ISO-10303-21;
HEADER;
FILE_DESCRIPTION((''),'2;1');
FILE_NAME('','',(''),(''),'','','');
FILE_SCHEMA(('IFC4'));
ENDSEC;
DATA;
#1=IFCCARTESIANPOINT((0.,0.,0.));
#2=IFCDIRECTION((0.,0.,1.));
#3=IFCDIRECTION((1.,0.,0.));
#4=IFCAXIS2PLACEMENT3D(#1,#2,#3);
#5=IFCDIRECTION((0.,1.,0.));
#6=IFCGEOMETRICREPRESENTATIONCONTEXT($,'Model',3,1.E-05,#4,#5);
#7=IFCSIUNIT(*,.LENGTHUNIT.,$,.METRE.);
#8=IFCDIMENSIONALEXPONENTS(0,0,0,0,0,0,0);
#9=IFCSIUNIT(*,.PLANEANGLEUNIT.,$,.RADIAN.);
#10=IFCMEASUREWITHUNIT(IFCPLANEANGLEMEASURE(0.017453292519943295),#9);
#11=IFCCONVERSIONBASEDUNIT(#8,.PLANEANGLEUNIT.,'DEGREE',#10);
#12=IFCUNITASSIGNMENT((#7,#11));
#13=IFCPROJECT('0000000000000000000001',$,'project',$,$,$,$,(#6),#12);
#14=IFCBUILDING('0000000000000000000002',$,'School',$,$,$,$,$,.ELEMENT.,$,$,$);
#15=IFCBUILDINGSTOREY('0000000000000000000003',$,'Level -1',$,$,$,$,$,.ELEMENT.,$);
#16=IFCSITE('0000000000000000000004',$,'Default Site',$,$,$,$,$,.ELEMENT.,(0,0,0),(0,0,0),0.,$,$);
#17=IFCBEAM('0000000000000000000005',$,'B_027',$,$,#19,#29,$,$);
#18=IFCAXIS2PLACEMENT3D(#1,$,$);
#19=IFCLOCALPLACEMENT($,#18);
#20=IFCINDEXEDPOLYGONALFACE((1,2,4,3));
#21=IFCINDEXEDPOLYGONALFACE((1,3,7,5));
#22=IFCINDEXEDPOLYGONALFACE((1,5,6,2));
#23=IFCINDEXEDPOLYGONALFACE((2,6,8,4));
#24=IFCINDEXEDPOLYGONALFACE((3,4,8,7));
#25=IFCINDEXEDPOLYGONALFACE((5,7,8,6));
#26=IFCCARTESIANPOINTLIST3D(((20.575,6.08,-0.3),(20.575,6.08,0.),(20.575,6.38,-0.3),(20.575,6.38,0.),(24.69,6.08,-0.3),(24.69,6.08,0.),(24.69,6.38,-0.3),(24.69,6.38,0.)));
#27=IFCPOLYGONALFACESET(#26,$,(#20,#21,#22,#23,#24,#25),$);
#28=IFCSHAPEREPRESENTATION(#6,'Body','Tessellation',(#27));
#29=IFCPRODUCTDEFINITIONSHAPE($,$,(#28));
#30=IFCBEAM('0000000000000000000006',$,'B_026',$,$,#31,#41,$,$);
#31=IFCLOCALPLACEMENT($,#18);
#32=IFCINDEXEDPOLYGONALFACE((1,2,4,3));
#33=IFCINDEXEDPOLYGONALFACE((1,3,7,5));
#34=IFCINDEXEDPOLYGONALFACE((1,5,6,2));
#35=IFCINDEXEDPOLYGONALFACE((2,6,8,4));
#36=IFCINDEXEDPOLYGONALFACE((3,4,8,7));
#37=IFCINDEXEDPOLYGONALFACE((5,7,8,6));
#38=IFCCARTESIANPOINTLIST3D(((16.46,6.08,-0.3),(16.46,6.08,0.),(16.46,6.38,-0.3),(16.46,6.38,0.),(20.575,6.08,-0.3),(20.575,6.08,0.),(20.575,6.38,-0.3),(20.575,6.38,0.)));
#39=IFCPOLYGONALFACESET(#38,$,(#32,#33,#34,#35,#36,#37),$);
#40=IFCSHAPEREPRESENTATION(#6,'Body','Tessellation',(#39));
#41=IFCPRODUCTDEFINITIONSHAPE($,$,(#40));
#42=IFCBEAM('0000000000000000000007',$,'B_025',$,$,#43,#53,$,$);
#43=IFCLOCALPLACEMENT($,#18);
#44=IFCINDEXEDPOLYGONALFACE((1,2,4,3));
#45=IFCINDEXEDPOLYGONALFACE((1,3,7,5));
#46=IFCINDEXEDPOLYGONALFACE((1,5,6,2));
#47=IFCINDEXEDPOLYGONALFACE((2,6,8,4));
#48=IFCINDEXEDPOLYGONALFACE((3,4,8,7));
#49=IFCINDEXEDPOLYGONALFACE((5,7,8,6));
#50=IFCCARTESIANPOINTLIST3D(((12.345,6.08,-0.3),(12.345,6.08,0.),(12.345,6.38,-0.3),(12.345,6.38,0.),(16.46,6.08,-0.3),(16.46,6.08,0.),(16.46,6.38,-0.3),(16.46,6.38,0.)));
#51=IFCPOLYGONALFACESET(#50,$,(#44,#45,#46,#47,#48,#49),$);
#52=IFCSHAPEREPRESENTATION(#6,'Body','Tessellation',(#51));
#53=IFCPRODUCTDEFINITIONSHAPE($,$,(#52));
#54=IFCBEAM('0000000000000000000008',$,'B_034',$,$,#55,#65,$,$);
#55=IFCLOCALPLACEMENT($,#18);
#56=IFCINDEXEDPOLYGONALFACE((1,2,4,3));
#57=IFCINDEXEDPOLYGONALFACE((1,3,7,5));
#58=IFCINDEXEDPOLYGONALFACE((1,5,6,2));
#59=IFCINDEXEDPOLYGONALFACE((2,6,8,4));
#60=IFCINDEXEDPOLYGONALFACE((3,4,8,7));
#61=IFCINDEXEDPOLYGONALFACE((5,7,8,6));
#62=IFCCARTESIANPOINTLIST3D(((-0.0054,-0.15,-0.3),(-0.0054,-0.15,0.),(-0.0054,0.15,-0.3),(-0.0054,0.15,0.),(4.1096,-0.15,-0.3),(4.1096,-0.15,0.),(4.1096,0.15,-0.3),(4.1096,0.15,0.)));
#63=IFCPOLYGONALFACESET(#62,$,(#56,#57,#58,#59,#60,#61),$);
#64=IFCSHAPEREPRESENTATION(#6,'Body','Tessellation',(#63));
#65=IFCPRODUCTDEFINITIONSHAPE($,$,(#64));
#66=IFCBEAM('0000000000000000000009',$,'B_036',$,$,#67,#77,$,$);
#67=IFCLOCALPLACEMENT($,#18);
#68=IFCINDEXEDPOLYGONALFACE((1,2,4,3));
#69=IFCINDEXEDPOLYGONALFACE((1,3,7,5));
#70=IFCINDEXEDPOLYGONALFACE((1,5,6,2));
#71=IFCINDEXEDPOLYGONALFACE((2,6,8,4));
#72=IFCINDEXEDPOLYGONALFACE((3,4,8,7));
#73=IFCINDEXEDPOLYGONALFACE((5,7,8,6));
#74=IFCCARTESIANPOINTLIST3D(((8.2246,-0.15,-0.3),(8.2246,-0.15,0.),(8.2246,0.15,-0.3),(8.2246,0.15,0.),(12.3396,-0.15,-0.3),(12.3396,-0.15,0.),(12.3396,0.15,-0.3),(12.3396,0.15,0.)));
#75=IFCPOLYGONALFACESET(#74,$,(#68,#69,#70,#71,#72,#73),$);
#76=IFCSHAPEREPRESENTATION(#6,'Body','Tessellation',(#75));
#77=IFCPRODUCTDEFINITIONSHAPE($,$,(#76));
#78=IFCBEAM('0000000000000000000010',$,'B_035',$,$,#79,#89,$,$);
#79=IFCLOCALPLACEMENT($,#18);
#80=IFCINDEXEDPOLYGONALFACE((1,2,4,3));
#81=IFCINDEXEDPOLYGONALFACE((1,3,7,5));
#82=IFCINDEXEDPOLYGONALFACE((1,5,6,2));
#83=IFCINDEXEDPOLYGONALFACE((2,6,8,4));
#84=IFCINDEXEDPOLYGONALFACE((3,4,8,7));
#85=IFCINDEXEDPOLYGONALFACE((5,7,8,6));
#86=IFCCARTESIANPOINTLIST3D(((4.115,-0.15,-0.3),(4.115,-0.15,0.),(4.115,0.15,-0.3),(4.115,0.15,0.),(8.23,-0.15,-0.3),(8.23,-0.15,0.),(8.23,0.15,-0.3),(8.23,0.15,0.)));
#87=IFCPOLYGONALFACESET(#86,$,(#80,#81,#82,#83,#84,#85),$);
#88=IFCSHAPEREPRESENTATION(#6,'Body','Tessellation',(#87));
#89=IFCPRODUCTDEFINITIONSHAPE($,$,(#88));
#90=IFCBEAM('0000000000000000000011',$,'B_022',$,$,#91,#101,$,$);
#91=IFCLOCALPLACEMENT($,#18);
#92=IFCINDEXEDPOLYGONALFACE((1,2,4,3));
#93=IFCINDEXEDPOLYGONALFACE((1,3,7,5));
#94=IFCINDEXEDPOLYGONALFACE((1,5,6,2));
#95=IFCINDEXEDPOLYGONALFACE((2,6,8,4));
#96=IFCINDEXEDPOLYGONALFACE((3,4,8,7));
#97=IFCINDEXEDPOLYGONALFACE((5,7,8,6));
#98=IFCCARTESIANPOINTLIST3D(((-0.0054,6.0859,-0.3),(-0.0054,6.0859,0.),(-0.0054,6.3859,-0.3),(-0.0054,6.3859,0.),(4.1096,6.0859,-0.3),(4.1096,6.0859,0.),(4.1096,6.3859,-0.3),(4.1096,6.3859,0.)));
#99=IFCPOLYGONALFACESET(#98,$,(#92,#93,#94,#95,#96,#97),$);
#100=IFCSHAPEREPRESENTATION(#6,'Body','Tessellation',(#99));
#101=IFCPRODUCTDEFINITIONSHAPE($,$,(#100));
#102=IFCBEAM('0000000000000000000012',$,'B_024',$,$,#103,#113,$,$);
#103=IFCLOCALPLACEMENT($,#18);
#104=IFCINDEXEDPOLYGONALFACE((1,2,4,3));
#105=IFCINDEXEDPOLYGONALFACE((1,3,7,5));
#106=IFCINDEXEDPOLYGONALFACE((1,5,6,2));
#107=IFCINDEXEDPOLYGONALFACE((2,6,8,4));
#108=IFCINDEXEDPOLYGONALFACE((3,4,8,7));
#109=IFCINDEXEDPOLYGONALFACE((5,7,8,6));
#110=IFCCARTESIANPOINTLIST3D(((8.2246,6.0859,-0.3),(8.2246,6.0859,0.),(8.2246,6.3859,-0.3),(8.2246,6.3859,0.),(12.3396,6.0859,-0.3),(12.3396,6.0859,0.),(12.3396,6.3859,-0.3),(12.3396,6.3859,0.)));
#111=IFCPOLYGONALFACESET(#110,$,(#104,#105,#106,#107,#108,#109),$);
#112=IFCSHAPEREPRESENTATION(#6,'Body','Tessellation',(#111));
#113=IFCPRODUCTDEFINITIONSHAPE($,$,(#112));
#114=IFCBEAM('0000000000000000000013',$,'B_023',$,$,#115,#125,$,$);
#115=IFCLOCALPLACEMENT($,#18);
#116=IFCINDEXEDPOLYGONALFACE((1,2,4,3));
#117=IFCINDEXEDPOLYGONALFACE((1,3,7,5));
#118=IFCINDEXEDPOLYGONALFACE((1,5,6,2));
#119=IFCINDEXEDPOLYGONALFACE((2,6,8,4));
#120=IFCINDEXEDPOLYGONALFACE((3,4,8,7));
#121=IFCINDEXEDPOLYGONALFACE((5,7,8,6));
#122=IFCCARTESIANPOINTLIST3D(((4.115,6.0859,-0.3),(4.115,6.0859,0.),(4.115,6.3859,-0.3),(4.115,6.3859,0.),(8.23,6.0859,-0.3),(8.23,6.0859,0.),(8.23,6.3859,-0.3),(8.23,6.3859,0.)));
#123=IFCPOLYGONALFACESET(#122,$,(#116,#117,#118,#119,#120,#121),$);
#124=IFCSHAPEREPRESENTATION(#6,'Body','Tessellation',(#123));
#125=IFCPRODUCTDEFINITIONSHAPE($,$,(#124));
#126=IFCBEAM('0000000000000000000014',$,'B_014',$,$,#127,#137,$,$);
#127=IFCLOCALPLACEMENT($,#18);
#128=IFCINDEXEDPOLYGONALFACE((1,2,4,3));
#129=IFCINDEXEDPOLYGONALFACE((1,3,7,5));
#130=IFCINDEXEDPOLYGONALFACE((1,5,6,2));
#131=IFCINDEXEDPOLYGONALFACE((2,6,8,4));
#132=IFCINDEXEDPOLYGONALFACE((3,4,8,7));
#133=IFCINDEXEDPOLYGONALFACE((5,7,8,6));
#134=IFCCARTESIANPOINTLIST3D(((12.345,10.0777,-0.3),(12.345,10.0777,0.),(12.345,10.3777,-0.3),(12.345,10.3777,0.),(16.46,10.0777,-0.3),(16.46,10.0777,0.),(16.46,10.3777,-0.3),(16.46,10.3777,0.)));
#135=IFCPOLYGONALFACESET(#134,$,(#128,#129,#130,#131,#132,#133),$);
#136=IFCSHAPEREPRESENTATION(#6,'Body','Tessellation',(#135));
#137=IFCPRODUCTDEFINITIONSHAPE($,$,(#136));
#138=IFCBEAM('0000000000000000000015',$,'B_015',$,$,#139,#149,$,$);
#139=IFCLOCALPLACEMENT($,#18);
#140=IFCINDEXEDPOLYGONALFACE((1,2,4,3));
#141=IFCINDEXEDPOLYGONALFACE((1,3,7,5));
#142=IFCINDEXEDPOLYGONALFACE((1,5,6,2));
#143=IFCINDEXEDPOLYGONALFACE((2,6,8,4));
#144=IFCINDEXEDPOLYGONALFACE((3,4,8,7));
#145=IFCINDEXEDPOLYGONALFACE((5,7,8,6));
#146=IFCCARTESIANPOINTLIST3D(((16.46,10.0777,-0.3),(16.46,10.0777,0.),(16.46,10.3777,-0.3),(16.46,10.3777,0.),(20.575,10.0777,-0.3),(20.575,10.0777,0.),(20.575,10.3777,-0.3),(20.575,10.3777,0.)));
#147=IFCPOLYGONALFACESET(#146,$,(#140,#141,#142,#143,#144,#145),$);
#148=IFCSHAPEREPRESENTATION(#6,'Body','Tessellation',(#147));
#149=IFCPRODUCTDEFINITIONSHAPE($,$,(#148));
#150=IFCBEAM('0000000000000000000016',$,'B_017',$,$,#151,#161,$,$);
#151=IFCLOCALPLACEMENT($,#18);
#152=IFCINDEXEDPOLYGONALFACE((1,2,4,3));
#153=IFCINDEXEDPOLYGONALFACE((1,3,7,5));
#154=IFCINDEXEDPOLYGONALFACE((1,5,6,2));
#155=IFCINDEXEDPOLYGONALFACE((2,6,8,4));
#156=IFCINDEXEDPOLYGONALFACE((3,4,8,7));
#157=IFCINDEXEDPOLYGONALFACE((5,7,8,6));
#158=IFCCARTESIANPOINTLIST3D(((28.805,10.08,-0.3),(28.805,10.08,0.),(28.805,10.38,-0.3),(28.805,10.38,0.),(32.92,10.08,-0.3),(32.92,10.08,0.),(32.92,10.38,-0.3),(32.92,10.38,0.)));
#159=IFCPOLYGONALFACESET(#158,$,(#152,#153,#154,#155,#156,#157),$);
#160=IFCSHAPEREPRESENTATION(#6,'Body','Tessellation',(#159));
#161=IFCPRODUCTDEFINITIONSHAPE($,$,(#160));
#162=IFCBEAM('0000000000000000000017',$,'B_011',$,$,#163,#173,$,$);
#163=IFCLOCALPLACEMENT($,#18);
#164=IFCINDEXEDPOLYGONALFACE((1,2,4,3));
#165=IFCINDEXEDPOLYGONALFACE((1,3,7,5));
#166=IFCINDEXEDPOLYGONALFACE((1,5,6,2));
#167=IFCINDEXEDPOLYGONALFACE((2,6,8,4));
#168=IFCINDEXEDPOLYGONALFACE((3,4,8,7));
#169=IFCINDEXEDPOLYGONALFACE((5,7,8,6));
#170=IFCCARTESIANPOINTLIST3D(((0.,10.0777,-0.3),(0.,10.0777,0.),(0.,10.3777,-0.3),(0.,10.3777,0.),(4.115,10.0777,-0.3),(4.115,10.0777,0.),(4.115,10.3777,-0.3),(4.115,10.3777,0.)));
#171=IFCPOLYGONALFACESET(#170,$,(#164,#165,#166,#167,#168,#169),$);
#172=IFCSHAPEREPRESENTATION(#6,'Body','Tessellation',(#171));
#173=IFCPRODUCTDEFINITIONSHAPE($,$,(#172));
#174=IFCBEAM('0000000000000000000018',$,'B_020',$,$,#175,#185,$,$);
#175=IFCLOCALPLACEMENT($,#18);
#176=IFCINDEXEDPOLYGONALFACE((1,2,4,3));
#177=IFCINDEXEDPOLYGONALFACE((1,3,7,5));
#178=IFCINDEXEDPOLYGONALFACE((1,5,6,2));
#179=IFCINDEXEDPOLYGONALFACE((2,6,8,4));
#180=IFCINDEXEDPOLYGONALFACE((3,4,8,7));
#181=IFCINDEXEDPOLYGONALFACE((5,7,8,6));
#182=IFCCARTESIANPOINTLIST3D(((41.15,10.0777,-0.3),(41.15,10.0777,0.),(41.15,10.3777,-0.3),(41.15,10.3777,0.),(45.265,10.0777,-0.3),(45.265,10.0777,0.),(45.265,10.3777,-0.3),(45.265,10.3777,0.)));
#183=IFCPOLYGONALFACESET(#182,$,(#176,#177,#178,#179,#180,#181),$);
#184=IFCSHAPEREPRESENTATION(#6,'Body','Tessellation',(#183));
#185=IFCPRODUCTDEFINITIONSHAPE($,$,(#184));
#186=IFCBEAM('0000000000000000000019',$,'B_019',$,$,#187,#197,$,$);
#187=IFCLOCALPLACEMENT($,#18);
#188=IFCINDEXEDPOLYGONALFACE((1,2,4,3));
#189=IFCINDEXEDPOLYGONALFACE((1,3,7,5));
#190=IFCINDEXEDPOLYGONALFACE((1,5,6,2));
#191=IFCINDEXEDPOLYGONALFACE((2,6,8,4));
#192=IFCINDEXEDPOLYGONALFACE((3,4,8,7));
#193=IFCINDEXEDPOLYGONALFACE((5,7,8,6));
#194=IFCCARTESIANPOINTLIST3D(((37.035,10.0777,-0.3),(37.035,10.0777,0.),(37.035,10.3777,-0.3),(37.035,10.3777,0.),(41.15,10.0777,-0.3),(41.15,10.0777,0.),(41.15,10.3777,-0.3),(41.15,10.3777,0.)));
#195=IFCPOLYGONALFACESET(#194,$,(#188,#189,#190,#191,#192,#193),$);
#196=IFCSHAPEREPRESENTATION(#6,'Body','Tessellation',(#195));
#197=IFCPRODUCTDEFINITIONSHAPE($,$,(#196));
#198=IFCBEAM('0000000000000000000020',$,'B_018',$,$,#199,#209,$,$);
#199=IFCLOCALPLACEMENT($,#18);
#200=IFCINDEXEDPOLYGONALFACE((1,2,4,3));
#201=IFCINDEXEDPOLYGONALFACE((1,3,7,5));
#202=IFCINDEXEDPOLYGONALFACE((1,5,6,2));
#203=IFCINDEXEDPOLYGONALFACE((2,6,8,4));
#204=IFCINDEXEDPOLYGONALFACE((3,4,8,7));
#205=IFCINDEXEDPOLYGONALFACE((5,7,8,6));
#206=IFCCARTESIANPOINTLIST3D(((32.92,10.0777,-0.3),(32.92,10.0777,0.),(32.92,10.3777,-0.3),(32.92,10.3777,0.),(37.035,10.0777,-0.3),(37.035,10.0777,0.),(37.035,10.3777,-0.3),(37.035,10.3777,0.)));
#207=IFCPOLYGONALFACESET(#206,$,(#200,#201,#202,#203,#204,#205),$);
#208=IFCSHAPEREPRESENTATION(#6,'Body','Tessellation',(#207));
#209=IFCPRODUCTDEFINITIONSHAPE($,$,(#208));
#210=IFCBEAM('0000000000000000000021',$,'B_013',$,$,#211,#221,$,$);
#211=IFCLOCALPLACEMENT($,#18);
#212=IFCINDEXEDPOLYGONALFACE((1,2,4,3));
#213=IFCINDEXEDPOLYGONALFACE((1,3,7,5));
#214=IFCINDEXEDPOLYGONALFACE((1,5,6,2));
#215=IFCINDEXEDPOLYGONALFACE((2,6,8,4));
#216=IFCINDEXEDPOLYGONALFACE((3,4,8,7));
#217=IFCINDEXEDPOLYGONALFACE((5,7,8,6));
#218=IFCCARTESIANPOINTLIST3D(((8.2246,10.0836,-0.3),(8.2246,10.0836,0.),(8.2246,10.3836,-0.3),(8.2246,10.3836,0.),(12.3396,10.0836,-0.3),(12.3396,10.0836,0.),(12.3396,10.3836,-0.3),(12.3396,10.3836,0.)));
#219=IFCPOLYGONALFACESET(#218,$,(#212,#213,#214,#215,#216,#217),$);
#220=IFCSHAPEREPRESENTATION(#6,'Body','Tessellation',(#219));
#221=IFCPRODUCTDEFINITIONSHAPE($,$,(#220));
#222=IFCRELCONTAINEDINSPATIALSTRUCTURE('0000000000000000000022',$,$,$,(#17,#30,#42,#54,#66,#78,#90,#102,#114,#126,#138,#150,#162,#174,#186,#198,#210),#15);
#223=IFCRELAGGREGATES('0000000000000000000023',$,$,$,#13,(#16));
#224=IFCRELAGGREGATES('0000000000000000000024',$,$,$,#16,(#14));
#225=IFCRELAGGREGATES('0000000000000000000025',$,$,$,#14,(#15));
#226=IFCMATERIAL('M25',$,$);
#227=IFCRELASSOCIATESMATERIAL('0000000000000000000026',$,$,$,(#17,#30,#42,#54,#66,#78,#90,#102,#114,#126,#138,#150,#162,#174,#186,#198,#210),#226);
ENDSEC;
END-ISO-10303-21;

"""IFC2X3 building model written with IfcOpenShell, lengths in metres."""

from ifc_helpers import new_model, entity, si_unit, converted_unit, direction, frame, frame_2d, origin_with_axes, place, context, project, spatial, rectangle, extrude, material, element, save


model = new_model("IFC2X3")

# Units and contexts
model_context = context("Model", 3, precision=1e-05, world=origin_with_axes(), true_north=direction((0.0, 1.0, 0.0)))
ifc_project = project(units=[si_unit("LENGTHUNIT", "METRE"), converted_unit("PLANEANGLEUNIT", "DEGREE", entity("IfcPlaneAngleMeasure", 0.017453292519943295), si_unit("PLANEANGLEUNIT", "RADIAN"), dimensions=[0, 0, 0, 0, 0, 0, 0])], contexts=[model_context])

# Site, building, storey
site = spatial("IfcSite", under=ifc_project, Name="Default Site", CompositionType="ELEMENT", RefLatitude=(0, 0, 0), RefLongitude=(0, 0, 0), RefElevation=0.0)
building = spatial("IfcBuilding", under=site, Name="School", CompositionType="ELEMENT")
storey = spatial("IfcBuildingStorey", under=building, Name="Level -1", CompositionType="ELEMENT")

# Beams
ifc_material = material(Name="M25")
placement = place(None, origin_with_axes())
element("IfcBeam", 1, at=placement, inside=storey, material=ifc_material, Name="B_027", context=model_context, shape_type="SweptSolid", body=[
    extrude(rectangle(XDim=0.3, YDim=0.3, at=frame_2d((0.0, 0.0), x_axis=(0.0, 1.0, 0.0))), frame((20.575, 6.23, -0.15), z_axis=(1.0, 0.0, 0.0), x_axis=(0.0, 0.0, -1.0)), (0.0, 0.0, 1.0), 4.115),
])
element("IfcBeam", 2, at=placement, inside=storey, material=ifc_material, Name="B_026", context=model_context, shape_type="SweptSolid", body=[
    extrude(rectangle(XDim=0.3, YDim=0.3, at=frame_2d((0.0, 0.0), x_axis=(0.0, 1.0, 0.0))), frame((16.46, 6.23, -0.15), z_axis=(1.0, 0.0, 0.0), x_axis=(0.0, 0.0, -1.0)), (0.0, 0.0, 1.0), 4.115),
])
element("IfcBeam", 3, at=placement, inside=storey, material=ifc_material, Name="B_025", context=model_context, shape_type="SweptSolid", body=[
    extrude(rectangle(XDim=0.3, YDim=0.3, at=frame_2d((0.0, 0.0), x_axis=(0.0, 1.0, 0.0))), frame((12.345, 6.23, -0.15), z_axis=(1.0, 0.0, 0.0), x_axis=(0.0, 0.0, -1.0)), (0.0, 0.0, 1.0), 4.115),
])
element("IfcBeam", 4, at=placement, inside=storey, material=ifc_material, Name="B_034", context=model_context, shape_type="SweptSolid", body=[
    extrude(rectangle(XDim=0.3, YDim=0.3, at=frame_2d((0.0, 0.0), x_axis=(0.0, 1.0, 0.0))), frame((-0.0054, 0.0, -0.15), z_axis=(1.0, 0.0, 0.0), x_axis=(0.0, 0.0, -1.0)), (0.0, 0.0, 1.0), 4.115),
])
element("IfcBeam", 5, at=placement, inside=storey, material=ifc_material, Name="B_036", context=model_context, shape_type="SweptSolid", body=[
    extrude(rectangle(XDim=0.3, YDim=0.3, at=frame_2d((0.0, 0.0), x_axis=(0.0, 1.0, 0.0))), frame((8.2246, 0.0, -0.15), z_axis=(1.0, 0.0, 0.0), x_axis=(0.0, 0.0, -1.0)), (0.0, 0.0, 1.0), 4.115),
])
element("IfcBeam", 6, at=placement, inside=storey, material=ifc_material, Name="B_035", context=model_context, shape_type="SweptSolid", body=[
    extrude(rectangle(XDim=0.3, YDim=0.3, at=frame_2d((0.0, 0.0), x_axis=(0.0, 1.0, 0.0))), frame((4.115, 0.0, -0.15), z_axis=(1.0, 0.0, 0.0), x_axis=(0.0, 0.0, -1.0)), (0.0, 0.0, 1.0), 4.115),
])
element("IfcBeam", 7, at=placement, inside=storey, material=ifc_material, Name="B_022", context=model_context, shape_type="SweptSolid", body=[
    extrude(rectangle(XDim=0.3, YDim=0.3, at=frame_2d((0.0, 0.0), x_axis=(0.0, 1.0, 0.0))), frame((-0.0054, 6.2359, -0.15), z_axis=(1.0, 0.0, 0.0), x_axis=(0.0, 0.0, -1.0)), (0.0, 0.0, 1.0), 4.115),
])
element("IfcBeam", 8, at=placement, inside=storey, material=ifc_material, Name="B_024", context=model_context, shape_type="SweptSolid", body=[
    extrude(rectangle(XDim=0.3, YDim=0.3, at=frame_2d((0.0, 0.0), x_axis=(0.0, 1.0, 0.0))), frame((8.2246, 6.2359, -0.15), z_axis=(1.0, 0.0, 0.0), x_axis=(0.0, 0.0, -1.0)), (0.0, 0.0, 1.0), 4.115),
])
element("IfcBeam", 9, at=placement, inside=storey, material=ifc_material, Name="B_023", context=model_context, shape_type="SweptSolid", body=[
    extrude(rectangle(XDim=0.3, YDim=0.3, at=frame_2d((0.0, 0.0), x_axis=(0.0, 1.0, 0.0))), frame((4.115, 6.2359, -0.15), z_axis=(1.0, 0.0, 0.0), x_axis=(0.0, 0.0, -1.0)), (0.0, 0.0, 1.0), 4.115),
])
element("IfcBeam", 10, at=placement, inside=storey, material=ifc_material, Name="B_014", context=model_context, shape_type="SweptSolid", body=[
    extrude(rectangle(XDim=0.3, YDim=0.3, at=frame_2d((0.0, 0.0), x_axis=(0.0, 1.0, 0.0))), frame((12.345, 10.2277, -0.15), z_axis=(1.0, 0.0, 0.0), x_axis=(0.0, 0.0, -1.0)), (0.0, 0.0, 1.0), 4.115),
])
element("IfcBeam", 11, at=placement, inside=storey, material=ifc_material, Name="B_015", context=model_context, shape_type="SweptSolid", body=[
    extrude(rectangle(XDim=0.3, YDim=0.3, at=frame_2d((0.0, 0.0), x_axis=(0.0, 1.0, 0.0))), frame((16.46, 10.2277, -0.15), z_axis=(1.0, 0.0, 0.0), x_axis=(0.0, 0.0, -1.0)), (0.0, 0.0, 1.0), 4.115),
])
element("IfcBeam", 12, at=placement, inside=storey, material=ifc_material, Name="B_017", context=model_context, shape_type="SweptSolid", body=[
    extrude(rectangle(XDim=0.3, YDim=0.3, at=frame_2d((0.0, 0.0), x_axis=(0.0, 1.0, 0.0))), frame((28.805, 10.23, -0.15), z_axis=(1.0, 0.0, 0.0), x_axis=(0.0, 0.0, -1.0)), (0.0, 0.0, 1.0), 4.115),
])
element("IfcBeam", 13, at=placement, inside=storey, material=ifc_material, Name="B_011", context=model_context, shape_type="SweptSolid", body=[
    extrude(rectangle(XDim=0.3, YDim=0.3, at=frame_2d((0.0, 0.0), x_axis=(0.0, 1.0, 0.0))), frame((0.0, 10.2277, -0.15), z_axis=(1.0, 0.0, 0.0), x_axis=(0.0, 0.0, -1.0)), (0.0, 0.0, 1.0), 4.115),
])
element("IfcBeam", 14, at=placement, inside=storey, material=ifc_material, Name="B_020", context=model_context, shape_type="SweptSolid", body=[
    extrude(rectangle(XDim=0.3, YDim=0.3, at=frame_2d((0.0, 0.0), x_axis=(0.0, 1.0, 0.0))), frame((41.15, 10.2277, -0.15), z_axis=(1.0, 0.0, 0.0), x_axis=(0.0, 0.0, -1.0)), (0.0, 0.0, 1.0), 4.115),
])
element("IfcBeam", 15, at=placement, inside=storey, material=ifc_material, Name="B_019", context=model_context, shape_type="SweptSolid", body=[
    extrude(rectangle(XDim=0.3, YDim=0.3, at=frame_2d((0.0, 0.0), x_axis=(0.0, 1.0, 0.0))), frame((37.035, 10.2277, -0.15), z_axis=(1.0, 0.0, 0.0), x_axis=(0.0, 0.0, -1.0)), (0.0, 0.0, 1.0), 4.115),
])
element("IfcBeam", 16, at=placement, inside=storey, material=ifc_material, Name="B_018", context=model_context, shape_type="SweptSolid", body=[
    extrude(rectangle(XDim=0.3, YDim=0.3, at=frame_2d((0.0, 0.0), x_axis=(0.0, 1.0, 0.0))), frame((32.92, 10.2277, -0.15), z_axis=(1.0, 0.0, 0.0), x_axis=(0.0, 0.0, -1.0)), (0.0, 0.0, 1.0), 4.115),
])
element("IfcBeam", 17, at=placement, inside=storey, material=ifc_material, Name="B_013", context=model_context, shape_type="SweptSolid", body=[
    extrude(rectangle(XDim=0.3, YDim=0.3, at=frame_2d((0.0, 0.0), x_axis=(0.0, 1.0, 0.0))), frame((8.2246, 10.2336, -0.15), z_axis=(1.0, 0.0, 0.0), x_axis=(0.0, 0.0, -1.0)), (0.0, 0.0, 1.0), 4.115),
])

save(model, "model.ifc")
